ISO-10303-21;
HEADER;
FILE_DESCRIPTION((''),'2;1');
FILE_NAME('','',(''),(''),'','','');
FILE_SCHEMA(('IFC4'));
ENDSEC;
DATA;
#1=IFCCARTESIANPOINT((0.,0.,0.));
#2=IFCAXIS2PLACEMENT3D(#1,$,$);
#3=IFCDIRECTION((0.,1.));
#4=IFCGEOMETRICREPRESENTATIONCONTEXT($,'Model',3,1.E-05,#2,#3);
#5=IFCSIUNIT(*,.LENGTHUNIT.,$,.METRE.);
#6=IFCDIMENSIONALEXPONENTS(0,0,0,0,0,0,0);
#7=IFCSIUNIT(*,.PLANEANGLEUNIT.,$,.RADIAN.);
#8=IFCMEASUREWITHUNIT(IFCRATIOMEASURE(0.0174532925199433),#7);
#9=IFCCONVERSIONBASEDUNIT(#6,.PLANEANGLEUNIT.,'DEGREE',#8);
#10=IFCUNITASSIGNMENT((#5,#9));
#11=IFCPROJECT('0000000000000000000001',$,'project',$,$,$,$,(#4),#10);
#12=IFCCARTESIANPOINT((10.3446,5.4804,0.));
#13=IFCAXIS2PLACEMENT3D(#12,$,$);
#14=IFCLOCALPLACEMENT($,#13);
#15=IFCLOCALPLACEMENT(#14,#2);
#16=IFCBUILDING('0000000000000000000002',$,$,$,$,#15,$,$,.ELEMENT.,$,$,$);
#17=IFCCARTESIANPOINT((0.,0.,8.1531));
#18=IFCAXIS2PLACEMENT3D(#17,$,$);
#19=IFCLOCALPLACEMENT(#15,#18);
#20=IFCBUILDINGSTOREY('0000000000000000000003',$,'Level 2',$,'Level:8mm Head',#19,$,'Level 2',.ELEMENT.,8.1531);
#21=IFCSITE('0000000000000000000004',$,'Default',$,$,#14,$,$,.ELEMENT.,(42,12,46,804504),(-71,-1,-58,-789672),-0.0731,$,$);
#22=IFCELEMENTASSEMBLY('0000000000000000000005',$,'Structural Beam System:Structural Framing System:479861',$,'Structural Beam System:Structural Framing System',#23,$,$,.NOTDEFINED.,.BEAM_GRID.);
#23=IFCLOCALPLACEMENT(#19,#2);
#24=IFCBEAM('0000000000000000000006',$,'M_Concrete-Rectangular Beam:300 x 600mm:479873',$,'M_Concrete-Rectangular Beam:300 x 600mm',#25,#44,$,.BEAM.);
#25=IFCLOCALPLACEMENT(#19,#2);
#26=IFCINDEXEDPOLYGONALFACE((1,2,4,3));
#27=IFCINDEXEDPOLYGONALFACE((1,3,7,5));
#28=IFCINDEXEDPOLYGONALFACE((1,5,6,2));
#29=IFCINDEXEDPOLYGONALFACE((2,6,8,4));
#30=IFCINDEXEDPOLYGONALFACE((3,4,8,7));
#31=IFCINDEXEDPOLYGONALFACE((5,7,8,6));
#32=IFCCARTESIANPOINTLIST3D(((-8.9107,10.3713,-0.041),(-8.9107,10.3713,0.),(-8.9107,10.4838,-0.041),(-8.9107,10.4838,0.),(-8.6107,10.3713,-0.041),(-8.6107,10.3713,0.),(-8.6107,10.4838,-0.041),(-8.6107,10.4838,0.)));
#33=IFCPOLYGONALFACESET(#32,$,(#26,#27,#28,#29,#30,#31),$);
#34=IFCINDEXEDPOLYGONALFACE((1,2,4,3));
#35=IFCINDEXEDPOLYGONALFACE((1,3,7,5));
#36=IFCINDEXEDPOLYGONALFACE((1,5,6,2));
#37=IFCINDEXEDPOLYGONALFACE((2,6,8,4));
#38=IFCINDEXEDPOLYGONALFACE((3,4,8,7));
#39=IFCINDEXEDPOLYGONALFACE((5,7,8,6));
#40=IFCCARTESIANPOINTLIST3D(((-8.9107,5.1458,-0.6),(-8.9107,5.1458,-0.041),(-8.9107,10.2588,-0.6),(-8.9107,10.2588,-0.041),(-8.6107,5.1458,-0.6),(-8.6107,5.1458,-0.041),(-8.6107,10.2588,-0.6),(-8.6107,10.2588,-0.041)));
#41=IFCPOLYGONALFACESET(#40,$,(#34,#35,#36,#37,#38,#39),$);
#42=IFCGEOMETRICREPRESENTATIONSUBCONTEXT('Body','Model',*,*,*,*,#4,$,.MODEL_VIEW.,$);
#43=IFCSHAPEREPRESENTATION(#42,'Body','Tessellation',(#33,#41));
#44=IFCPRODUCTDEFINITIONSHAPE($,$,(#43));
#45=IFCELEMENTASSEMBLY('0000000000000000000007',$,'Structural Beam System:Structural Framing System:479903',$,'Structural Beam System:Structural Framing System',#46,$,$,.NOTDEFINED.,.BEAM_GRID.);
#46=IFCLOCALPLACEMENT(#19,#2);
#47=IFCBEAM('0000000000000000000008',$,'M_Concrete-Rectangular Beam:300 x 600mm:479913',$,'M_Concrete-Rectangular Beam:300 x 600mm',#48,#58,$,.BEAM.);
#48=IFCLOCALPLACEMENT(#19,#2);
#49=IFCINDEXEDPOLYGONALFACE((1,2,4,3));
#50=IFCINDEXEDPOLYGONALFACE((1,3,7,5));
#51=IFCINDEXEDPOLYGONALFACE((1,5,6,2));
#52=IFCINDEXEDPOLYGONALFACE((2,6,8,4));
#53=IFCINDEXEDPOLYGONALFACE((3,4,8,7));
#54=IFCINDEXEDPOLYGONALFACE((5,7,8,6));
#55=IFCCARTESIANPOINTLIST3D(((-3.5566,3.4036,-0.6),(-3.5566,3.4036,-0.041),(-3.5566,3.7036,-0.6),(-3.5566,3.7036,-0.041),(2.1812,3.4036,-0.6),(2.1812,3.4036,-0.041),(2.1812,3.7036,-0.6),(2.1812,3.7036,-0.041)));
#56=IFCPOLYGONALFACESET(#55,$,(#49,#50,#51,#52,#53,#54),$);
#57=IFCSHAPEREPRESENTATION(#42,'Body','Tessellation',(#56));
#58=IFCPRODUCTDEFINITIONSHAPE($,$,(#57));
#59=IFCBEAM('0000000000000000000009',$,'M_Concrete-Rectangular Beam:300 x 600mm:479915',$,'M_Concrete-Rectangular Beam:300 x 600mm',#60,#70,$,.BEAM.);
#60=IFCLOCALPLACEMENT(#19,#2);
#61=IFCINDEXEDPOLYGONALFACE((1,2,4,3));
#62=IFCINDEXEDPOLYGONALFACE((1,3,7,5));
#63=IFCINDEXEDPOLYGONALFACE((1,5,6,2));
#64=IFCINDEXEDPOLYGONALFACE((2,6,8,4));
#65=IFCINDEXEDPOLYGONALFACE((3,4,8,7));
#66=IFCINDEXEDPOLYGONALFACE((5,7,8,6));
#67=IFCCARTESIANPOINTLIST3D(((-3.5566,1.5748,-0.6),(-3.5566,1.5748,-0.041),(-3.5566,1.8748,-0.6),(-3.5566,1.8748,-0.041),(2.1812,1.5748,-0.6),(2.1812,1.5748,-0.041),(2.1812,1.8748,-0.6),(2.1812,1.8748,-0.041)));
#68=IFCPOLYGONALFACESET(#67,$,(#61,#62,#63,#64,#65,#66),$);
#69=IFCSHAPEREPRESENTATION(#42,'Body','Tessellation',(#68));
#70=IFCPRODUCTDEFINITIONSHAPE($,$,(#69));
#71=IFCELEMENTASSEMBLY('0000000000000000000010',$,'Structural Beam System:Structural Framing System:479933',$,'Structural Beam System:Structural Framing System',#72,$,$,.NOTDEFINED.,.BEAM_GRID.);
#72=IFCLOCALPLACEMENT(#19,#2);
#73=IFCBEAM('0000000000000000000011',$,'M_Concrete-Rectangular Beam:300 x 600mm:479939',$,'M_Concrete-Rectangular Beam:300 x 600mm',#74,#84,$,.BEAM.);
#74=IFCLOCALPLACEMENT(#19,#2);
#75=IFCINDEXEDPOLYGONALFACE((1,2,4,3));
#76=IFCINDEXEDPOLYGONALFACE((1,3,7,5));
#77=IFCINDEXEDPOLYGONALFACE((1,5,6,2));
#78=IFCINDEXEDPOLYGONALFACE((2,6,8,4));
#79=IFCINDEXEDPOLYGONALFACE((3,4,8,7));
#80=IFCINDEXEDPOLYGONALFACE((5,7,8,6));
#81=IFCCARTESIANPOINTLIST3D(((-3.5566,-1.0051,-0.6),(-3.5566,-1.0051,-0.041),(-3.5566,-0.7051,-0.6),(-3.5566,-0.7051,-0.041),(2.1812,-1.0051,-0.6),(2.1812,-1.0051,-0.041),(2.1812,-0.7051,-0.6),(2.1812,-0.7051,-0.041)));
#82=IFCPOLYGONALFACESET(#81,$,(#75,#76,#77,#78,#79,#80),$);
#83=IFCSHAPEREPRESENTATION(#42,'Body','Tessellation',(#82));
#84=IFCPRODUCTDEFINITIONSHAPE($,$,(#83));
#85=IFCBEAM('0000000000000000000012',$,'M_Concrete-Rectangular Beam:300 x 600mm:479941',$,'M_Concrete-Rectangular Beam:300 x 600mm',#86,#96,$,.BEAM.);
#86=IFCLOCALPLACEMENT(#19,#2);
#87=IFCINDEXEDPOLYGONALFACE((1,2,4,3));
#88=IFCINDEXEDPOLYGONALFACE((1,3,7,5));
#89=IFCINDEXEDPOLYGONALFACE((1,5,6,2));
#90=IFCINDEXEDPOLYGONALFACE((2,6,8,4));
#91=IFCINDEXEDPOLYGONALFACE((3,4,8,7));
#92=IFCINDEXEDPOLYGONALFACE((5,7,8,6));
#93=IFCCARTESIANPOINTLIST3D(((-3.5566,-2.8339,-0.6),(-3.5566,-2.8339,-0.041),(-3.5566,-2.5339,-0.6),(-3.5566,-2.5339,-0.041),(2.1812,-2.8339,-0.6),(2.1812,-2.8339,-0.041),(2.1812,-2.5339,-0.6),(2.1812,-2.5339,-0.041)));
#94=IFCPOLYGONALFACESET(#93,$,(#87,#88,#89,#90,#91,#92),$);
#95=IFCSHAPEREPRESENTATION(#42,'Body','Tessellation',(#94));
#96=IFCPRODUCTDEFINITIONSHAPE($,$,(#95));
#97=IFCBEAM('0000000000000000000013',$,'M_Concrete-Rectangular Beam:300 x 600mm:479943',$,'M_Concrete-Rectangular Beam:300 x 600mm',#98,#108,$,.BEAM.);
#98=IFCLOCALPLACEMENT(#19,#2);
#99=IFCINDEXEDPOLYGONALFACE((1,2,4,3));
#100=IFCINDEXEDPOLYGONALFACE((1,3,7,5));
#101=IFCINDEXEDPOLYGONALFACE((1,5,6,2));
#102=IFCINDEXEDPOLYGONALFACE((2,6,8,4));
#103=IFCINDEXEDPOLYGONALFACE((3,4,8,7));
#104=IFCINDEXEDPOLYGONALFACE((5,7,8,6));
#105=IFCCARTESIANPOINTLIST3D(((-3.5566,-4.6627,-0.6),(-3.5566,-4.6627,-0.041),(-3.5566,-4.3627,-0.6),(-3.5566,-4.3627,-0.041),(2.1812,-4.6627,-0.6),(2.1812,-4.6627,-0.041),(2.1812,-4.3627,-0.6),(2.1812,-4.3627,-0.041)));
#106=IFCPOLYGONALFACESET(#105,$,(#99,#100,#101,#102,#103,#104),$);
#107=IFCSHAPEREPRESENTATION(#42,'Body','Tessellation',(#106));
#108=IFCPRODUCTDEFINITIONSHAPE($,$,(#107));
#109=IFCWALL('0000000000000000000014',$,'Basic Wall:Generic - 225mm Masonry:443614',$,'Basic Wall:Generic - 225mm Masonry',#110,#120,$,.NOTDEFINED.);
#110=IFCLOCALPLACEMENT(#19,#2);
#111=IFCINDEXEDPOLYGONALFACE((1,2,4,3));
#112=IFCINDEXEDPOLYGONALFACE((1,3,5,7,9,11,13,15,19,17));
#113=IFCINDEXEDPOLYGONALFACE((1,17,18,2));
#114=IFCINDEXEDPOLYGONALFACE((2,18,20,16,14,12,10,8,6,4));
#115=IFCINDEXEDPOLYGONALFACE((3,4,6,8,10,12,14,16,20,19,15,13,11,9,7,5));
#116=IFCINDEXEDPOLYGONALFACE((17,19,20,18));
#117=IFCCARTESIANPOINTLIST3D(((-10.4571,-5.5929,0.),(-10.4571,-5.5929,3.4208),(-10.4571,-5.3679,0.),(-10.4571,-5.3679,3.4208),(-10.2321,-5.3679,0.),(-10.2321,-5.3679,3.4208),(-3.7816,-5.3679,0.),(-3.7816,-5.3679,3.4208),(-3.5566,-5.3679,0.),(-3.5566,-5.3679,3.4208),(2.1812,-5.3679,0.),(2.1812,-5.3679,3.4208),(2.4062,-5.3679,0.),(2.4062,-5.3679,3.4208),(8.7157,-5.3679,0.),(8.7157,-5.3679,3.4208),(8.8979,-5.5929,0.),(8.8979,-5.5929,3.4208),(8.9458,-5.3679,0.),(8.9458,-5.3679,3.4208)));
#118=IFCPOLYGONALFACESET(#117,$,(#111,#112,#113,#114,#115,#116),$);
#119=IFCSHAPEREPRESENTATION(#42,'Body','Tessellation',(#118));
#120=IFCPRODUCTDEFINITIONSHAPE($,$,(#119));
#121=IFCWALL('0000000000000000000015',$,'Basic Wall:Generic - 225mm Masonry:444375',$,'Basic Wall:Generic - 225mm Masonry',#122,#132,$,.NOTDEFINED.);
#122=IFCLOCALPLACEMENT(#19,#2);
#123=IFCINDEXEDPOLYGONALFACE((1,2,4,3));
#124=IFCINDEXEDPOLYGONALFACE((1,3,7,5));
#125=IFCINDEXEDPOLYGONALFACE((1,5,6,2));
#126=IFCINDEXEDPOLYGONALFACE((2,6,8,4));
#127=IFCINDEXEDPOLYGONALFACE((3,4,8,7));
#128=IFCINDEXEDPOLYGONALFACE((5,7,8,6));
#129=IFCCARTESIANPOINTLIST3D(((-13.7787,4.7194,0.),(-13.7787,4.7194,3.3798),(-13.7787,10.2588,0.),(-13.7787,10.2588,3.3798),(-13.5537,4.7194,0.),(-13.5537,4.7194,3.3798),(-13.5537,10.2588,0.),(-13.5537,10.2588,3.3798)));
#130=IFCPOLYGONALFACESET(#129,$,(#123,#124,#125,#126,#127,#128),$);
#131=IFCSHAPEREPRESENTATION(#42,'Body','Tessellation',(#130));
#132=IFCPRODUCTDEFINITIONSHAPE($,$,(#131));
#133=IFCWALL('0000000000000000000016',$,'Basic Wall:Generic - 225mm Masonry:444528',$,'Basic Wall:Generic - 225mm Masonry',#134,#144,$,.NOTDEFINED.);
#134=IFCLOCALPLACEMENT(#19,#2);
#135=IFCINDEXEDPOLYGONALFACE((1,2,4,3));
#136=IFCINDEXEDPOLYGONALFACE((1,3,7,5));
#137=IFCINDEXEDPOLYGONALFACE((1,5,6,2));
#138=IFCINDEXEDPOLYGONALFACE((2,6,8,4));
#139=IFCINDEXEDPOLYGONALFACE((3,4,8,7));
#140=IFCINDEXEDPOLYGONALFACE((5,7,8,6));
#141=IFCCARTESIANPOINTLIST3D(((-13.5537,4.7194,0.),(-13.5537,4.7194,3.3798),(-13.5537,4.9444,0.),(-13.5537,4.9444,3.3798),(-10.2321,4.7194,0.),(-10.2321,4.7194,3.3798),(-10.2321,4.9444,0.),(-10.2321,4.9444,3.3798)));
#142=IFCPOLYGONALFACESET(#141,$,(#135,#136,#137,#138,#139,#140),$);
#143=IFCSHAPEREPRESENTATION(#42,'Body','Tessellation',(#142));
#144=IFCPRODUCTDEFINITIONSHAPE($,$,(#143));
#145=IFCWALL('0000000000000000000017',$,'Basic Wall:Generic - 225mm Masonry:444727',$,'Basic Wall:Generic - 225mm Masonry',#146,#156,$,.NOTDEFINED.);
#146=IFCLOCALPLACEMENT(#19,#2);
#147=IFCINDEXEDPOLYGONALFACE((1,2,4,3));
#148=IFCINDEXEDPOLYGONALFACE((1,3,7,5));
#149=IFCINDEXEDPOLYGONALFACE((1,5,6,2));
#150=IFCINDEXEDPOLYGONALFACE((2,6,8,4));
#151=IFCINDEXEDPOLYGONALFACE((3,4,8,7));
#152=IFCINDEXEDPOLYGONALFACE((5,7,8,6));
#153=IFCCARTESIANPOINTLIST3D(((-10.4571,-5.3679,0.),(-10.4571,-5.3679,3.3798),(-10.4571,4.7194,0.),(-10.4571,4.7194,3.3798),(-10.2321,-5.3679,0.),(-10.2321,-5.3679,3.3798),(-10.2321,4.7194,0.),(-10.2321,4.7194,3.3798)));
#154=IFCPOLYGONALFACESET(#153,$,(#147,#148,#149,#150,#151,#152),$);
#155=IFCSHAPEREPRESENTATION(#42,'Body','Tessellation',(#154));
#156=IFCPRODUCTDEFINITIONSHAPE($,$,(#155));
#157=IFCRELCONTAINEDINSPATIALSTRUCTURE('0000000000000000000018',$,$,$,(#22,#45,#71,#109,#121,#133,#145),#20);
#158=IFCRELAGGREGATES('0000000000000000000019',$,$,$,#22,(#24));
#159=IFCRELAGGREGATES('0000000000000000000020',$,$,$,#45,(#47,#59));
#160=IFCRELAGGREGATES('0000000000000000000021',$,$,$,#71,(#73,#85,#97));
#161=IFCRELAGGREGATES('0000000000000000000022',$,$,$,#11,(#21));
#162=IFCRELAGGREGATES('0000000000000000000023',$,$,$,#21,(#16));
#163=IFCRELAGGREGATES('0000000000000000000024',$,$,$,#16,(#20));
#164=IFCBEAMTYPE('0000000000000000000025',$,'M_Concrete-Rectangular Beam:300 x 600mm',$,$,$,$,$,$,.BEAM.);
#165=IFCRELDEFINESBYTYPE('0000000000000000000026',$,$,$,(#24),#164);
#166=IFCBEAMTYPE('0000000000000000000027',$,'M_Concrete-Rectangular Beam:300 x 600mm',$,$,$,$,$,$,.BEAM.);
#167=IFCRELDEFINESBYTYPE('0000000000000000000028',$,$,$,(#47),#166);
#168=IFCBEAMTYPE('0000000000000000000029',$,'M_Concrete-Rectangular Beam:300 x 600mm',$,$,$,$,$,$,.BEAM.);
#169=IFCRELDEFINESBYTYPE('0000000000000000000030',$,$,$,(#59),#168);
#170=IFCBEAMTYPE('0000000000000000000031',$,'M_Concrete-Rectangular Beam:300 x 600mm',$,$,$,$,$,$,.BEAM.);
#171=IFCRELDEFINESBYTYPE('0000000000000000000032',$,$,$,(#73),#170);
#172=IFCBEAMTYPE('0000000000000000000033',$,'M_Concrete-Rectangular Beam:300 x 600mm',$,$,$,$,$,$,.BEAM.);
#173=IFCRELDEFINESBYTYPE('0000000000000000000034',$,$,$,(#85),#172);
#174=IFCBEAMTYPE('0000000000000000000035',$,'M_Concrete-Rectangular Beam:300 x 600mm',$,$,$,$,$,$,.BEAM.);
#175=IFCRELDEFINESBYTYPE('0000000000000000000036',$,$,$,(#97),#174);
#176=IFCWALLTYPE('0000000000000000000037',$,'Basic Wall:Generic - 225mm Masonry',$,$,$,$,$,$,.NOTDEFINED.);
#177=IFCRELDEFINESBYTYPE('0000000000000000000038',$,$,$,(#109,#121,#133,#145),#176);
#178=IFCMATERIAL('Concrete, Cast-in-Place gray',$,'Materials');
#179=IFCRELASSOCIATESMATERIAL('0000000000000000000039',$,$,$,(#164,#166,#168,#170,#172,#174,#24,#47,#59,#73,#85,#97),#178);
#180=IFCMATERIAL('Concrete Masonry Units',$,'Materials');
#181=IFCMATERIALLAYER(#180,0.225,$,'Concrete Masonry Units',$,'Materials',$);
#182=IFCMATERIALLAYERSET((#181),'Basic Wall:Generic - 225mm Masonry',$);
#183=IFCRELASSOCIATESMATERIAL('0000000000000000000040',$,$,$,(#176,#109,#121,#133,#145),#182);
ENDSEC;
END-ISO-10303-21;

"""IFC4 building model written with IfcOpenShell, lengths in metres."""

from ifc_helpers import new_model, entity, si_unit, converted_unit, direction, frame, frame_2d, origin, place, context, subcontext, project, spatial, polyline, rectangle, outline, extrude, clip, bounded_halfspace, source, transform, mapped, material, layer, layer_set, layer_usage, material_profile, profile_set, profile_usage, type_object, type_shapes, element, aggregate, save


model = new_model("IFC4")

# Units and contexts
model_context = context("Model", 3, precision=1e-05, world=origin(), true_north=direction((0.0, 1.0)))
body_context = subcontext(model_context, "Body", "Model", "MODEL_VIEW")
ifc_project = project(units=[si_unit("LENGTHUNIT", "METRE"), converted_unit("PLANEANGLEUNIT", "DEGREE", entity("IfcRatioMeasure", 0.0174532925199433), si_unit("PLANEANGLEUNIT", "RADIAN"), dimensions=[0, 0, 0, 0, 0, 0, 0])], contexts=[model_context])

# Site, building, storey
site_placement = place(None, frame((10.3446, 5.4804, 0.0)))
site = spatial("IfcSite", under=ifc_project, at=site_placement, Name="Default", CompositionType="ELEMENT", RefLatitude=(42, 12, 46, 804504), RefLongitude=(-71, -1, -58, -789672), RefElevation=-0.0731)
building_placement = place(site_placement, origin())
building = spatial("IfcBuilding", under=site, at=building_placement, CompositionType="ELEMENT")
storey_placement = place(building_placement, frame((0.0, 0.0, 8.1531)))
storey = spatial("IfcBuildingStorey", under=building, at=storey_placement, Name="Level 2", ObjectType="Level:8mm Head", LongName="Level 2", CompositionType="ELEMENT", Elevation=8.1531)

# Element assemblies, beams
ifc_material_1 = material(Name="Concrete, Cast-in-Place gray", Category="Materials")
ifc_material_profile = material_profile(ifc_material_1, rectangle(XDim=0.559, YDim=0.3, at=frame_2d((0.0, 0.0), x_axis=(1.0, 0.0))), Name="300 x 600mm")
ifc_profile_set = profile_set([ifc_material_profile], Name="300 x 600mm")
assembly_1_placement = place(storey_placement, origin())
assembly_1 = element("IfcElementAssembly", 1, at=assembly_1_placement, inside=storey, Name="Structural Beam System:Structural Framing System:479861", ObjectType="Structural Beam System:Structural Framing System", AssemblyPlace="NOTDEFINED", PredefinedType="BEAM_GRID")
ifc_profile_usage_1 = profile_usage(ifc_profile_set, cardinal=8)
beam_type_1 = type_object("IfcBeamType", Name="M_Concrete-Rectangular Beam:300 x 600mm", PredefinedType="BEAM", material=ifc_profile_set)
shared_shape_1 = source(origin(), body_context, "Body", "SweptSolid", [
    extrude(rectangle(XDim=0.041, YDim=0.3, at=frame_2d((0.0, 0.0), x_axis=(0.0, 1.0))), frame((-8.7607, 10.4838, 8.1326), z_axis=(0.0, -1.0, 0.0), x_axis=(-1.0, 0.0, 0.0)), (0.0, 0.0, 1.0), 0.1125),
    extrude(rectangle(XDim=0.559, YDim=0.3, at=frame_2d((0.0, 0.0), x_axis=(0.0, 1.0))), frame((-8.7607, 10.2588, 7.8326), z_axis=(0.0, -1.0, 0.0), x_axis=(-1.0, 0.0, 0.0)), (0.0, 0.0, 1.0), 5.113),
])
type_shapes(beam_type_1, [shared_shape_1])
beam_1_placement = place(assembly_1_placement, frame((0.0, 0.0, -8.1531)))
beam_1 = element("IfcBeam", 2, at=beam_1_placement, type_object=beam_type_1, material=ifc_profile_usage_1, Name="M_Concrete-Rectangular Beam:300 x 600mm:479873", ObjectType="M_Concrete-Rectangular Beam:300 x 600mm", PredefinedType="BEAM", context=body_context, shape_type="MappedRepresentation", body=[
    mapped(shared_shape_1, transform((0.0, 0.0, 0.0), scale=1.0)),
])
aggregate(assembly_1, [beam_1])
assembly_2_placement = place(storey_placement, origin())
assembly_2 = element("IfcElementAssembly", 3, at=assembly_2_placement, inside=storey, Name="Structural Beam System:Structural Framing System:479903", ObjectType="Structural Beam System:Structural Framing System", AssemblyPlace="NOTDEFINED", PredefinedType="BEAM_GRID")
ifc_profile_usage_2 = profile_usage(ifc_profile_set, cardinal=8)
beam_type_2 = type_object("IfcBeamType", Name="M_Concrete-Rectangular Beam:300 x 600mm", PredefinedType="BEAM", material=ifc_profile_set)
shared_shape_2 = source(origin(), body_context, "Body", "SweptSolid", [
    extrude(rectangle(XDim=0.559, YDim=0.3, at=frame_2d((0.0, 0.0), x_axis=(1.0, 0.0))), frame((-3.5566, 3.5536, 7.8326), z_axis=(1.0, 0.0, 0.0), x_axis=(0.0, 0.0, -1.0)), (0.0, 0.0, 1.0), 5.7377),
])
type_shapes(beam_type_2, [shared_shape_2])
beam_2_placement = place(assembly_2_placement, frame((0.0, 0.0, -8.1531)))
beam_2 = element("IfcBeam", 4, at=beam_2_placement, type_object=beam_type_2, material=ifc_profile_usage_2, Name="M_Concrete-Rectangular Beam:300 x 600mm:479913", ObjectType="M_Concrete-Rectangular Beam:300 x 600mm", PredefinedType="BEAM", context=body_context, shape_type="MappedRepresentation", body=[
    mapped(shared_shape_2, transform((0.0, 0.0, 0.0), scale=1.0)),
])
ifc_profile_usage_3 = profile_usage(ifc_profile_set, cardinal=8)
beam_type_3 = type_object("IfcBeamType", Name="M_Concrete-Rectangular Beam:300 x 600mm", PredefinedType="BEAM", material=ifc_profile_set)
shared_shape_3 = source(origin(), body_context, "Body", "SweptSolid", [
    extrude(rectangle(XDim=0.559, YDim=0.3, at=frame_2d((0.0, 0.0), x_axis=(1.0, 0.0))), frame((-3.5566, 1.7248, 7.8326), z_axis=(1.0, 0.0, 0.0), x_axis=(0.0, 0.0, -1.0)), (0.0, 0.0, 1.0), 5.7377),
])
type_shapes(beam_type_3, [shared_shape_3])
beam_3_placement = place(assembly_2_placement, frame((0.0, 0.0, -8.1531)))
beam_3 = element("IfcBeam", 5, at=beam_3_placement, type_object=beam_type_3, material=ifc_profile_usage_3, Name="M_Concrete-Rectangular Beam:300 x 600mm:479915", ObjectType="M_Concrete-Rectangular Beam:300 x 600mm", PredefinedType="BEAM", context=body_context, shape_type="MappedRepresentation", body=[
    mapped(shared_shape_3, transform((0.0, 0.0, 0.0), scale=1.0)),
])
aggregate(assembly_2, [beam_2, beam_3])
assembly_3_placement = place(storey_placement, origin())
assembly_3 = element("IfcElementAssembly", 6, at=assembly_3_placement, inside=storey, Name="Structural Beam System:Structural Framing System:479933", ObjectType="Structural Beam System:Structural Framing System", AssemblyPlace="NOTDEFINED", PredefinedType="BEAM_GRID")
ifc_profile_usage_4 = profile_usage(ifc_profile_set, cardinal=8)
beam_type_4 = type_object("IfcBeamType", Name="M_Concrete-Rectangular Beam:300 x 600mm", PredefinedType="BEAM", material=ifc_profile_set)
shared_shape_4 = source(origin(), body_context, "Body", "SweptSolid", [
    extrude(rectangle(XDim=0.559, YDim=0.3, at=frame_2d((0.0, 0.0), x_axis=(1.0, 0.0))), frame((-3.5566, -0.8551, 7.8326), z_axis=(1.0, 0.0, 0.0), x_axis=(0.0, 0.0, -1.0)), (0.0, 0.0, 1.0), 5.7377),
])
type_shapes(beam_type_4, [shared_shape_4])
beam_4_placement = place(assembly_3_placement, frame((0.0, 0.0, -8.1531)))
beam_4 = element("IfcBeam", 7, at=beam_4_placement, type_object=beam_type_4, material=ifc_profile_usage_4, Name="M_Concrete-Rectangular Beam:300 x 600mm:479939", ObjectType="M_Concrete-Rectangular Beam:300 x 600mm", PredefinedType="BEAM", context=body_context, shape_type="MappedRepresentation", body=[
    mapped(shared_shape_4, transform((0.0, 0.0, 0.0), scale=1.0)),
])
ifc_profile_usage_5 = profile_usage(ifc_profile_set, cardinal=8)
beam_type_5 = type_object("IfcBeamType", Name="M_Concrete-Rectangular Beam:300 x 600mm", PredefinedType="BEAM", material=ifc_profile_set)
shared_shape_5 = source(origin(), body_context, "Body", "SweptSolid", [
    extrude(rectangle(XDim=0.559, YDim=0.3, at=frame_2d((0.0, 0.0), x_axis=(1.0, 0.0))), frame((-3.5566, -2.6839, 7.8326), z_axis=(1.0, 0.0, 0.0), x_axis=(0.0, 0.0, -1.0)), (0.0, 0.0, 1.0), 5.7377),
])
type_shapes(beam_type_5, [shared_shape_5])
beam_5_placement = place(assembly_3_placement, frame((0.0, 0.0, -8.1531)))
beam_5 = element("IfcBeam", 8, at=beam_5_placement, type_object=beam_type_5, material=ifc_profile_usage_5, Name="M_Concrete-Rectangular Beam:300 x 600mm:479941", ObjectType="M_Concrete-Rectangular Beam:300 x 600mm", PredefinedType="BEAM", context=body_context, shape_type="MappedRepresentation", body=[
    mapped(shared_shape_5, transform((0.0, 0.0, 0.0), scale=1.0)),
])
ifc_profile_usage_6 = profile_usage(ifc_profile_set, cardinal=8)
beam_type_6 = type_object("IfcBeamType", Name="M_Concrete-Rectangular Beam:300 x 600mm", PredefinedType="BEAM", material=ifc_profile_set)
shared_shape_6 = source(origin(), body_context, "Body", "SweptSolid", [
    extrude(rectangle(XDim=0.559, YDim=0.3, at=frame_2d((0.0, 0.0), x_axis=(1.0, 0.0))), frame((-3.5566, -4.5127, 7.8326), z_axis=(1.0, 0.0, 0.0), x_axis=(0.0, 0.0, -1.0)), (0.0, 0.0, 1.0), 5.7377),
])
type_shapes(beam_type_6, [shared_shape_6])
beam_6_placement = place(assembly_3_placement, frame((0.0, 0.0, -8.1531)))
beam_6 = element("IfcBeam", 9, at=beam_6_placement, type_object=beam_type_6, material=ifc_profile_usage_6, Name="M_Concrete-Rectangular Beam:300 x 600mm:479943", ObjectType="M_Concrete-Rectangular Beam:300 x 600mm", PredefinedType="BEAM", context=body_context, shape_type="MappedRepresentation", body=[
    mapped(shared_shape_6, transform((0.0, 0.0, 0.0), scale=1.0)),
])
aggregate(assembly_3, [beam_4, beam_5, beam_6])

# Walls
ifc_material_2 = material(Name="Concrete Masonry Units", Category="Materials")
ifc_layer = layer(ifc_material_2, 0.225, Name="Concrete Masonry Units", Category="Materials")
ifc_layer_set = layer_set([ifc_layer], Name="Basic Wall:Generic - 225mm Masonry")
ifc_layer_usage_1 = layer_usage(ifc_layer_set, "AXIS2", "NEGATIVE", 0.1125)
wall_type = type_object("IfcWallType", Name="Basic Wall:Generic - 225mm Masonry", PredefinedType="NOTDEFINED", material=ifc_layer_set)
wall_1_placement = place(storey_placement, frame((-10.4571, -5.4804, 0.0)))
element("IfcWall", 10, at=wall_1_placement, inside=storey, type_object=wall_type, material=ifc_layer_usage_1, Name="Basic Wall:Generic - 225mm Masonry:443614", ObjectType="Basic Wall:Generic - 225mm Masonry", PredefinedType="NOTDEFINED", context=body_context, shape_type="SweptSolid", body=[
    extrude(outline(polyline([(19.3551, -0.1125), (19.4029, 0.1125), (19.1729, 0.1125), (12.8633, 0.1125), (12.6383, 0.1125), (6.9006, 0.1125), (6.6756, 0.1125), (0.225, 0.1125), (0.0, 0.1125), (0.0, -0.1125), (19.3551, -0.1125)])), origin(), (0.0, 0.0, 1.0), 3.4208),
])
ifc_layer_usage_2 = layer_usage(ifc_layer_set, "AXIS2", "NEGATIVE", 0.1125)
wall_2_placement = place(storey_placement, frame((-13.6662, 10.2588, 0.0), z_axis=(0.0, 0.0, 1.0), x_axis=(0.0, -1.0, 0.0)))
element("IfcWall", 11, at=wall_2_placement, inside=storey, type_object=wall_type, material=ifc_layer_usage_2, Name="Basic Wall:Generic - 225mm Masonry:444375", ObjectType="Basic Wall:Generic - 225mm Masonry", PredefinedType="NOTDEFINED", context=body_context, shape_type="Clipping", body=[
    clip(extrude(rectangle(XDim=5.5394, YDim=0.225, at=frame_2d((2.7697, 0.0), x_axis=(-1.0, 0.0))), origin(), (0.0, 0.0, 1.0), 3.3798), bounded_halfspace(frame((5.4269, 0.0, 3.3798), z_axis=(0.0, 0.0, -1.0), x_axis=(1.0, 0.0, 0.0)), True, frame((5.4269, 0.0, 3.3798)), polyline([(0.0, 0.0), (0.0, 0.1125), (-0.1125, 0.1125), (-5.4269, 0.1125), (-5.4269, 0.0), (0.0, 0.0)]))),
])
ifc_layer_usage_3 = layer_usage(ifc_layer_set, "AXIS2", "NEGATIVE", 0.1125)
wall_3_placement = place(storey_placement, frame((-13.5537, 4.8319, 0.0)))
element("IfcWall", 12, at=wall_3_placement, inside=storey, type_object=wall_type, material=ifc_layer_usage_3, Name="Basic Wall:Generic - 225mm Masonry:444528", ObjectType="Basic Wall:Generic - 225mm Masonry", PredefinedType="NOTDEFINED", context=body_context, shape_type="Clipping", body=[
    clip(extrude(rectangle(XDim=3.3216, YDim=0.225, at=frame_2d((1.6608, 0.0), x_axis=(-1.0, 0.0))), origin(), (0.0, 0.0, 1.0), 3.3798), bounded_halfspace(frame((3.3216, 0.0, 3.3798), z_axis=(0.0, 0.0, -1.0), x_axis=(0.0, -1.0, 0.0)), True, frame((3.3216, 0.0, 3.3798)), polyline([(0.0, 0.0), (0.0, 0.0889), (0.0, 0.1125), (-0.2073, 0.1125), (-0.5073, 0.1125), (-3.3216, 0.1125), (-3.3216, 0.0), (0.0, 0.0)]))),
])
ifc_layer_usage_4 = layer_usage(ifc_layer_set, "AXIS2", "NEGATIVE", 0.1125)
wall_4_placement = place(storey_placement, frame((-10.3446, 4.7194, 0.0), z_axis=(0.0, 0.0, 1.0), x_axis=(0.0, -1.0, 0.0)))
element("IfcWall", 13, at=wall_4_placement, inside=storey, type_object=wall_type, material=ifc_layer_usage_4, Name="Basic Wall:Generic - 225mm Masonry:444727", ObjectType="Basic Wall:Generic - 225mm Masonry", PredefinedType="NOTDEFINED", context=body_context, shape_type="Clipping", body=[
    clip(extrude(rectangle(XDim=10.0873, YDim=0.225, at=frame_2d((5.0437, 0.0), x_axis=(-1.0, 0.0))), origin(), (0.0, 0.0, 1.0), 3.3798), bounded_halfspace(frame((10.0873, 0.0, 3.3798), z_axis=(0.0, 0.0, -1.0), x_axis=(0.0, -1.0, 0.0)), True, frame((10.0873, 0.0, 3.3798)), polyline([(0.0, 0.0), (0.0, 0.1125), (-10.0873, 0.1125), (-10.0873, 0.0), (0.0, 0.0)]))),
])

save(model, "model.ifc")
